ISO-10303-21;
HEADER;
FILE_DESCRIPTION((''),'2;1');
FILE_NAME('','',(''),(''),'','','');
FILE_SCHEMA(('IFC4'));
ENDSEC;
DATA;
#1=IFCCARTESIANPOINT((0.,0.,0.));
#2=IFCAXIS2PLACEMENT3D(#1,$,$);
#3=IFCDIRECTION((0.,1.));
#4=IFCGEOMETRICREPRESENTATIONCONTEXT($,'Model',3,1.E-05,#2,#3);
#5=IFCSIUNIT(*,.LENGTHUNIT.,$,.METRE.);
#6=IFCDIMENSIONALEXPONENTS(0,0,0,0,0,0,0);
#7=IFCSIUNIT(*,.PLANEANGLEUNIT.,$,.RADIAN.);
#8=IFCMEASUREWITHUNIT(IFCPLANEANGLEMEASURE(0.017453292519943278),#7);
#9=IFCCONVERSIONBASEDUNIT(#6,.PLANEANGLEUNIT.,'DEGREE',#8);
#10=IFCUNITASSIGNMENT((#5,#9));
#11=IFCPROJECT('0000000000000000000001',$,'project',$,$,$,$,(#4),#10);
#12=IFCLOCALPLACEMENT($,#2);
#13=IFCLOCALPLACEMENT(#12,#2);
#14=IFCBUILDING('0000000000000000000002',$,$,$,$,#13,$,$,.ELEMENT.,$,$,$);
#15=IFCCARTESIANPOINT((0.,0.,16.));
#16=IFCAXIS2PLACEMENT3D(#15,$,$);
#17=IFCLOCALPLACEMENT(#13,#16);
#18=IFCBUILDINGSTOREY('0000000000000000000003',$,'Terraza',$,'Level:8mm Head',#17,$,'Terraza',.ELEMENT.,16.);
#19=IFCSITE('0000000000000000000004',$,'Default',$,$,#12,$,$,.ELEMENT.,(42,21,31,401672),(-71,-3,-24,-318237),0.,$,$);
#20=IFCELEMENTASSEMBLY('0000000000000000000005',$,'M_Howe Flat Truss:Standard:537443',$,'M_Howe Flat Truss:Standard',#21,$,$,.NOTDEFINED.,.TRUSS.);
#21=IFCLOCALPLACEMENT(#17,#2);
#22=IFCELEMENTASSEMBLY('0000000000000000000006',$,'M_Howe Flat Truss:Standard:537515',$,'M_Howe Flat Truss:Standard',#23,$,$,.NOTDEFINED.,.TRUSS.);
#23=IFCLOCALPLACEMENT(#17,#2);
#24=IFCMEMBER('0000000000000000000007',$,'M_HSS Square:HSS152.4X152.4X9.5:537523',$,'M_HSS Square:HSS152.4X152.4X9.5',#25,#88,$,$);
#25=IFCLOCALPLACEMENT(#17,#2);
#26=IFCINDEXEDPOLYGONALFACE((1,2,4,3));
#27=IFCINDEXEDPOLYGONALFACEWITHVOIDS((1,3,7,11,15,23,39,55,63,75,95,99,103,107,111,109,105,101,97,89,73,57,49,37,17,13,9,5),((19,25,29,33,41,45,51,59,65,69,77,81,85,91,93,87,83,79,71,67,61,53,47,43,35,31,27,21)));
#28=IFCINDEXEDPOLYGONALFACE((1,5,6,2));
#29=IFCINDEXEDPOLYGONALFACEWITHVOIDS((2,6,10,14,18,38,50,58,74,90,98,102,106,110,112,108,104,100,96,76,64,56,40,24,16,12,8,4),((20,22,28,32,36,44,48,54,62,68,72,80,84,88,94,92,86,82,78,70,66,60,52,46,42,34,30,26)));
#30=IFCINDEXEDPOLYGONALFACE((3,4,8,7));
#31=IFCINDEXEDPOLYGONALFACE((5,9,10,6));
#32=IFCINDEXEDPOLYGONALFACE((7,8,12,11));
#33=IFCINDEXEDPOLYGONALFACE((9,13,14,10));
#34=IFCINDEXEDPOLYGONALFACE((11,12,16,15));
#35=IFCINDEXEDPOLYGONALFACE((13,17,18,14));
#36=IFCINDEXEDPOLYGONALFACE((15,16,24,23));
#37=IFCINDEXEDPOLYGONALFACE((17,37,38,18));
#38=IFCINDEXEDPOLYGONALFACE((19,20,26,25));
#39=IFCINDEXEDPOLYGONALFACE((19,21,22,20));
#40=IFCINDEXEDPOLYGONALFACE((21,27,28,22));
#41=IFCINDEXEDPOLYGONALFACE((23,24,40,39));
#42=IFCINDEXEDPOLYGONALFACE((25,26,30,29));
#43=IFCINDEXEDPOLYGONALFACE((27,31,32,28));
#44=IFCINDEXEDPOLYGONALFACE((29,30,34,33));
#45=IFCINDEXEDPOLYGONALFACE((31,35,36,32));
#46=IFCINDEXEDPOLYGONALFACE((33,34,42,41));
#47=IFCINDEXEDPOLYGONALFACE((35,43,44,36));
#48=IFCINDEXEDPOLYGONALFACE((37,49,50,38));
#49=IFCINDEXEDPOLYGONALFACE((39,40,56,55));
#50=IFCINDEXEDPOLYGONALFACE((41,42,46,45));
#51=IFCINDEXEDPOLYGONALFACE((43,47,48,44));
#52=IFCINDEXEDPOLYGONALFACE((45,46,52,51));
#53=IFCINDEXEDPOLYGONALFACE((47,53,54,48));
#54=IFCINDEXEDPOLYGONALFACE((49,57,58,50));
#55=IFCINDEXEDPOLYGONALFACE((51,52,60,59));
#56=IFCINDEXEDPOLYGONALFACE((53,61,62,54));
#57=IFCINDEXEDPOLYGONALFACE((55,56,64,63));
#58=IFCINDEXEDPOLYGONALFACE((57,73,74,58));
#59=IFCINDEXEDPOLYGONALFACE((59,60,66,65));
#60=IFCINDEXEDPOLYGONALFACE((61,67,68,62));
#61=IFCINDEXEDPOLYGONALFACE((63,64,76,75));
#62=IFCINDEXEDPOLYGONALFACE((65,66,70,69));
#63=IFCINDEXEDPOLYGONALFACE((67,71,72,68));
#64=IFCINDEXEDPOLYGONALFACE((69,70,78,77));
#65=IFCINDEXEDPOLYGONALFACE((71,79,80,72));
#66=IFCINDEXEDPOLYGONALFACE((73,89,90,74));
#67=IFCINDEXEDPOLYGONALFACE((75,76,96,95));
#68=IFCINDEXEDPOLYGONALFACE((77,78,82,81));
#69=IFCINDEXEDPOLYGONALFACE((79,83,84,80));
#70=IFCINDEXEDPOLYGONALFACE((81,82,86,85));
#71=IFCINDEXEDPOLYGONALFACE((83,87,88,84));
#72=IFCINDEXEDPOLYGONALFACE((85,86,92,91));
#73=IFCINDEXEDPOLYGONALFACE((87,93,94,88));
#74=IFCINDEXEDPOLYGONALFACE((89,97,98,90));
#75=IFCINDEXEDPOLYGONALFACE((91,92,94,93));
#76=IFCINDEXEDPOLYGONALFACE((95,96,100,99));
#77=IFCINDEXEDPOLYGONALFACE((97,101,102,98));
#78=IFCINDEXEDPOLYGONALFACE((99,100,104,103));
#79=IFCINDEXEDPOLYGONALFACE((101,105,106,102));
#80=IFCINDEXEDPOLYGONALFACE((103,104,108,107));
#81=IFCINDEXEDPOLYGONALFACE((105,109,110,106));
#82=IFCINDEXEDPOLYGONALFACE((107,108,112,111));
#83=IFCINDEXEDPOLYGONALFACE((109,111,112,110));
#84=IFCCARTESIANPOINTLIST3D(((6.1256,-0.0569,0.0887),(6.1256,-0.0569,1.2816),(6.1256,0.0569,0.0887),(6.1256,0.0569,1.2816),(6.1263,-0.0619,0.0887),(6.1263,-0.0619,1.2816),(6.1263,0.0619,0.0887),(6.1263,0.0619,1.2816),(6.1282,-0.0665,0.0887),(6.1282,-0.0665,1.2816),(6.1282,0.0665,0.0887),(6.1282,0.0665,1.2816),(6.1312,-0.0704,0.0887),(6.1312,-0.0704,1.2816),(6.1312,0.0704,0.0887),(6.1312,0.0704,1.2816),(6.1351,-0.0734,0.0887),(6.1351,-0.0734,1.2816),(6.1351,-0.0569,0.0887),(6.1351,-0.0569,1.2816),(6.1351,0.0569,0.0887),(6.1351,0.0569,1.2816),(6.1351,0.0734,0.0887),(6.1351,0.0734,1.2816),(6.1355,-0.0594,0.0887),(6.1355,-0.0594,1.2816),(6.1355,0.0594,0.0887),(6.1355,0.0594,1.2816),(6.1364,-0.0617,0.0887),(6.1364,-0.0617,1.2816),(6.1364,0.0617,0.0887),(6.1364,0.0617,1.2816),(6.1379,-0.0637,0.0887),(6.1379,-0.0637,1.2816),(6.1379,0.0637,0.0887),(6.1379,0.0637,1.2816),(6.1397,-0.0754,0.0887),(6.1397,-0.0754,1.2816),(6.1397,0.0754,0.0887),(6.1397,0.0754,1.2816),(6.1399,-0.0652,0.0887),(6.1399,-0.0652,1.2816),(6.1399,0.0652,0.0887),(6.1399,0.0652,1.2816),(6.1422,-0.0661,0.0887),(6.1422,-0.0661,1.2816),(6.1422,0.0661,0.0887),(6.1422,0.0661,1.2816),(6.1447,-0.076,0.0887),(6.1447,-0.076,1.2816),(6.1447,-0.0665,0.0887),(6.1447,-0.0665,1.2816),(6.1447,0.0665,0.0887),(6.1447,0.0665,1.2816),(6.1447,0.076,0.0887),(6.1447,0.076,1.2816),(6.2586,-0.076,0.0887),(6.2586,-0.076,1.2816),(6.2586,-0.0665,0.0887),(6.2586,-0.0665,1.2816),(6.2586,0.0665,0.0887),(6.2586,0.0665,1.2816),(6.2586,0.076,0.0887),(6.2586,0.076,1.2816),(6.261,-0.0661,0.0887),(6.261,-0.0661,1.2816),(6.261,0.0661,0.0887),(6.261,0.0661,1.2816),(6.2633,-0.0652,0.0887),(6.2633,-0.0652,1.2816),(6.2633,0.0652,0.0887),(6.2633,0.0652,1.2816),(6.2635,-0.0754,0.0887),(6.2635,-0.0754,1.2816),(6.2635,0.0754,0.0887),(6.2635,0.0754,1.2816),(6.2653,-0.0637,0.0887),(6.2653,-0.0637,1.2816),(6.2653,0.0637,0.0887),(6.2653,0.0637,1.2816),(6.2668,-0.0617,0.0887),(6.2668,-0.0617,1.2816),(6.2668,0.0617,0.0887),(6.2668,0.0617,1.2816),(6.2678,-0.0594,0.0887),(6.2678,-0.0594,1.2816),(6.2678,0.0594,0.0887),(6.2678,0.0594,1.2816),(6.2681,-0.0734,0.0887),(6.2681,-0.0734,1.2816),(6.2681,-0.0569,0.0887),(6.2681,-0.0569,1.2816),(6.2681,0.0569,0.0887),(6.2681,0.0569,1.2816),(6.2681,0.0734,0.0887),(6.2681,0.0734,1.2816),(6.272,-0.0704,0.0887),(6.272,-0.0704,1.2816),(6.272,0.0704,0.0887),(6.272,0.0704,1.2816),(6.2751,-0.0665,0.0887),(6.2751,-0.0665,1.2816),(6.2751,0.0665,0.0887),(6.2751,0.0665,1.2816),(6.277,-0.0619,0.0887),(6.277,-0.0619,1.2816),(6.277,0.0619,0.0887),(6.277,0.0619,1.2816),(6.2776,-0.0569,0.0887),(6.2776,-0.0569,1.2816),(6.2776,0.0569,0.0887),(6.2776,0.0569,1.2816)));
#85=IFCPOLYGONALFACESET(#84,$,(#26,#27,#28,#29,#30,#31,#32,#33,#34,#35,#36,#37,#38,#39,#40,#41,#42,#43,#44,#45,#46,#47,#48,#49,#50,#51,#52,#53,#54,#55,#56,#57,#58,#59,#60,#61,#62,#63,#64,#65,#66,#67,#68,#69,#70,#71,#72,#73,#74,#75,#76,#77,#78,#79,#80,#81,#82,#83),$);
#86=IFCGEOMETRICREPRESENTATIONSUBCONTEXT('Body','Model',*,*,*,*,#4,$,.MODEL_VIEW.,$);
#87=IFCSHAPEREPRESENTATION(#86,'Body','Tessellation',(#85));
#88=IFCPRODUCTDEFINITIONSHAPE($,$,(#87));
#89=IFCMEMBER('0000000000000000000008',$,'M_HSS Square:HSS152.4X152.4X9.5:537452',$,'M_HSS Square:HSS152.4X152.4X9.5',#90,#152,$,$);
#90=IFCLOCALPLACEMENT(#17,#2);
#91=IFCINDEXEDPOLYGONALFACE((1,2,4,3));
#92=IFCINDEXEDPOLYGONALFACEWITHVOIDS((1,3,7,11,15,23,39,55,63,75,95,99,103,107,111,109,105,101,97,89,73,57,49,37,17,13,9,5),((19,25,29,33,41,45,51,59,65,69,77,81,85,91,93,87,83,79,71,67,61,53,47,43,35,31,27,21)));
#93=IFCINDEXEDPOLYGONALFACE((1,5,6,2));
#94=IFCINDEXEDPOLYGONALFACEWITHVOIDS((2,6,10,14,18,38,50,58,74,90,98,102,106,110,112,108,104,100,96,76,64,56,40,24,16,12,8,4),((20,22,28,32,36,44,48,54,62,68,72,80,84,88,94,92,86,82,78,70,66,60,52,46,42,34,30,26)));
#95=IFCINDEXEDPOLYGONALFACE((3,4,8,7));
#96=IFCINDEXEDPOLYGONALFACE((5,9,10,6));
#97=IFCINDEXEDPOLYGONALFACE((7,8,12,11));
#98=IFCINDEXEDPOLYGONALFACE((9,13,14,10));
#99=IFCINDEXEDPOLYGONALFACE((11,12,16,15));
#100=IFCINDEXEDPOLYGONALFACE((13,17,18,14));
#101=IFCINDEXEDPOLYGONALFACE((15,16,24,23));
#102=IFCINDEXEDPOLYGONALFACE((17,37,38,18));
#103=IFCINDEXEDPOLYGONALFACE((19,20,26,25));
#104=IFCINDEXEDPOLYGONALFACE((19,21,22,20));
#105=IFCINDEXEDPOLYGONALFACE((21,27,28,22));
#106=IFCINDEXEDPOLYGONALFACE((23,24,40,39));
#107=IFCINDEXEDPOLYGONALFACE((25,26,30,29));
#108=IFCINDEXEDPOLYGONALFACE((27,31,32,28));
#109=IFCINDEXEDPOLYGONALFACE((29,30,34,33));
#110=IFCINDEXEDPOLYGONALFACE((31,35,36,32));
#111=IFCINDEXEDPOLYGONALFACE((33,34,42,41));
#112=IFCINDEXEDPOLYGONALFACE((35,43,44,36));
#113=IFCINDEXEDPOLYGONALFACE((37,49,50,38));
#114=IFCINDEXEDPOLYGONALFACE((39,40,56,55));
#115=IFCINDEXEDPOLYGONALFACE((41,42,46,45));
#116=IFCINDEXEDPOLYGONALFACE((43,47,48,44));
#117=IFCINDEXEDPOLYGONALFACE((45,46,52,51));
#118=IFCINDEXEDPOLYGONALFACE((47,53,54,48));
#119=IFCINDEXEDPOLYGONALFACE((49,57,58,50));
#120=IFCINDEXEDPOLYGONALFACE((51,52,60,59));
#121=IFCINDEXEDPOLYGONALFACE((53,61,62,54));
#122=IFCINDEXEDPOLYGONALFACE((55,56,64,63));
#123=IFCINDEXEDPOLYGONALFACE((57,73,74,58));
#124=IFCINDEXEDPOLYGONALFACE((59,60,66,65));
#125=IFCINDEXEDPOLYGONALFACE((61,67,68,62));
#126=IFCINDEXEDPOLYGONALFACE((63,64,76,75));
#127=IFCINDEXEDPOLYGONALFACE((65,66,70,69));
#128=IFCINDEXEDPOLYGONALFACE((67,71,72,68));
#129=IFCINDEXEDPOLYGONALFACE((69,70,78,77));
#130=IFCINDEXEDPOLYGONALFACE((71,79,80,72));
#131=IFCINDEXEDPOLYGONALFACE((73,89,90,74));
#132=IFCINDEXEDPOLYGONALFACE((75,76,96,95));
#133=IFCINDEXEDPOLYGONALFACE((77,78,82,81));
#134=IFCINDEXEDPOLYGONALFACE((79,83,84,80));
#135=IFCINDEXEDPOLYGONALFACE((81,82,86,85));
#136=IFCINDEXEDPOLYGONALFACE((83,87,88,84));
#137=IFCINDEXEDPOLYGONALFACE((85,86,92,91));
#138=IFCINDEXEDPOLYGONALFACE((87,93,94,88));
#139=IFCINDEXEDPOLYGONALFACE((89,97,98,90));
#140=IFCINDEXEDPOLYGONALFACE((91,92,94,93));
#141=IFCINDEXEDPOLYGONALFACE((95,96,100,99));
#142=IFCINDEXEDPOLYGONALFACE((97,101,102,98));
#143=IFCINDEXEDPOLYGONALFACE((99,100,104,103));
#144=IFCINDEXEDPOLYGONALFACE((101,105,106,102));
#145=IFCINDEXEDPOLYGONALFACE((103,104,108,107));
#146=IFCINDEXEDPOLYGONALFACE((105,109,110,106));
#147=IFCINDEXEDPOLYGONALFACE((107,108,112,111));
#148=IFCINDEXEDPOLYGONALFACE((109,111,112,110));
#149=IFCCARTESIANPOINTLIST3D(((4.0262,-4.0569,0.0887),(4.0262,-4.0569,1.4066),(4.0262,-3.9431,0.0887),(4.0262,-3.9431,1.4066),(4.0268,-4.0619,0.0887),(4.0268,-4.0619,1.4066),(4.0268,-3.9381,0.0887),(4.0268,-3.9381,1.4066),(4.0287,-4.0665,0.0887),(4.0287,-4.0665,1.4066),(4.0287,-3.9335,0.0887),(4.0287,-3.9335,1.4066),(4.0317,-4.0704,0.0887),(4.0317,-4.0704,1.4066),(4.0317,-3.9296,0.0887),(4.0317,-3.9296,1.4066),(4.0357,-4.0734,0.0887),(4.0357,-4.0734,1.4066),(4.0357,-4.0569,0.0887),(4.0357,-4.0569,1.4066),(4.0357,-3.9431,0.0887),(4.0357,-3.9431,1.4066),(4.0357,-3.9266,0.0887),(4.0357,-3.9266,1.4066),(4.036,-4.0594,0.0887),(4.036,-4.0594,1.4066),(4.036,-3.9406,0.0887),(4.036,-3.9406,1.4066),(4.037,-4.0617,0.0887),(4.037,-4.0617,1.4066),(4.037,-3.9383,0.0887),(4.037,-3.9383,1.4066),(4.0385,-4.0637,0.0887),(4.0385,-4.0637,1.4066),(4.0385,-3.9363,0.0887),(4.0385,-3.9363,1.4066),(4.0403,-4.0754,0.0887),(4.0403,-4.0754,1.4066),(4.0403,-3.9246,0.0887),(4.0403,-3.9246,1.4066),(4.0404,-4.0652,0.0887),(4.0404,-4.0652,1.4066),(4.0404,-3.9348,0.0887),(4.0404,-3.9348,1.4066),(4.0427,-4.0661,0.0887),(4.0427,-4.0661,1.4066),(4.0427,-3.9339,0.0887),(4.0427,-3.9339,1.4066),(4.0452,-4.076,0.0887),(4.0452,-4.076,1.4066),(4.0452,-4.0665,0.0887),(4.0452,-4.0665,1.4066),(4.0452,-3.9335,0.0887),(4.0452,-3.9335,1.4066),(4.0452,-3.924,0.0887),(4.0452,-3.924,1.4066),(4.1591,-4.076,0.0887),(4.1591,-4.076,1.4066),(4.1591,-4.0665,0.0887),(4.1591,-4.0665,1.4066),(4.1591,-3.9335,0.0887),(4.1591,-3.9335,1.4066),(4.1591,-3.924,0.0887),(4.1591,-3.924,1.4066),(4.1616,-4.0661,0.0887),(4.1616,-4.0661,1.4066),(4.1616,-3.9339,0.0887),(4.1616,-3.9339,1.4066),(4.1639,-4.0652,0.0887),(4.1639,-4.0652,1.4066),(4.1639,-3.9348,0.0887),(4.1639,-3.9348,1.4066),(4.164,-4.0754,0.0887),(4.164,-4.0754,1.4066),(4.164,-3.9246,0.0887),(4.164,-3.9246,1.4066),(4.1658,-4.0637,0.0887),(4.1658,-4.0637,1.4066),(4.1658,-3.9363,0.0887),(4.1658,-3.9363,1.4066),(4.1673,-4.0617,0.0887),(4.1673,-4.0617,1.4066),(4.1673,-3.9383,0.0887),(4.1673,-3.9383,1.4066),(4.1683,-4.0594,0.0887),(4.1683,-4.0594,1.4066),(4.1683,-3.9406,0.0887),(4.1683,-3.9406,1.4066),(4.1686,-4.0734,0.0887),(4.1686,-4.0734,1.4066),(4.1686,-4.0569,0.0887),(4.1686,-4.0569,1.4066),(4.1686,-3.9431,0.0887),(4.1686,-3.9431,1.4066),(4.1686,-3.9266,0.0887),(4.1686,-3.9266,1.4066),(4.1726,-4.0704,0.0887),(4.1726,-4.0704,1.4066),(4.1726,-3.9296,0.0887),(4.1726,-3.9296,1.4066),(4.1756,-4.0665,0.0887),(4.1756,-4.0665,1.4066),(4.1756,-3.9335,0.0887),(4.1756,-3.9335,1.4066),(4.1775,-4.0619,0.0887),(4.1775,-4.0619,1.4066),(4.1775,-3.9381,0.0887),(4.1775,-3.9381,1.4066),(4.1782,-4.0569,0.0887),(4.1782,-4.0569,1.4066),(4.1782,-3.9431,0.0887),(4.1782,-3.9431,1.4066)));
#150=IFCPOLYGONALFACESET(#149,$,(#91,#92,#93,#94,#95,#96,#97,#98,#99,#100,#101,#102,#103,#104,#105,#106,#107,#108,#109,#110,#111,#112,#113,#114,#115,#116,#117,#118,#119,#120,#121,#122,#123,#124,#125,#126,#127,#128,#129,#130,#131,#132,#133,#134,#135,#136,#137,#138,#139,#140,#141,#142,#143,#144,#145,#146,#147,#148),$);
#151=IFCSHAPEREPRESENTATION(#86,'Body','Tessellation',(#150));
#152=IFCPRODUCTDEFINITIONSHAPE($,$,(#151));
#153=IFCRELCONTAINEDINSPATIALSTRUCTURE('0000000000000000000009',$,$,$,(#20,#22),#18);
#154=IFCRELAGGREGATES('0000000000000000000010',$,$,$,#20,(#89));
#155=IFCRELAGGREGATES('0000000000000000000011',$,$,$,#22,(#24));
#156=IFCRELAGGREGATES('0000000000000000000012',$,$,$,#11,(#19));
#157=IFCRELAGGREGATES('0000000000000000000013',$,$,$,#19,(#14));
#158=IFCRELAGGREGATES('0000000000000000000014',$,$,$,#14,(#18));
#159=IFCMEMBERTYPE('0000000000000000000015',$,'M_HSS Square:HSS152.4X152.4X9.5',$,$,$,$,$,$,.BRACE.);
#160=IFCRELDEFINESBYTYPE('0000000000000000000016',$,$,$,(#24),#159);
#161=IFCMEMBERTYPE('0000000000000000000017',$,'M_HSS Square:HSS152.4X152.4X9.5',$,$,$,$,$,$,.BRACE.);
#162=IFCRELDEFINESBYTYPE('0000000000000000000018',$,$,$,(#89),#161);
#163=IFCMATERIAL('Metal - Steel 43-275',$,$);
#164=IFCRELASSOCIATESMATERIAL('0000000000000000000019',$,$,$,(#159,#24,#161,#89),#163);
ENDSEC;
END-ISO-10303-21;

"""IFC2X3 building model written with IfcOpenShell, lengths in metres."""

from ifc_helpers import new_model, entity, si_unit, converted_unit, direction, frame, frame_2d, origin, place, context, subcontext, project, spatial, polyline, circle_curve, parameter, trimmed, segment, composite_curve, outline, extrude, source, transform, mapped, material, type_object, type_shapes, element, aggregate, save


model = new_model("IFC2X3")

# Units and contexts
model_context = context("Model", 3, precision=1e-05, world=origin(), true_north=direction((0.0, 1.0)))
body_context = subcontext(model_context, "Body", "Model", "MODEL_VIEW")
ifc_project = project(units=[si_unit("LENGTHUNIT", "METRE"), converted_unit("PLANEANGLEUNIT", "DEGREE", entity("IfcPlaneAngleMeasure", 0.017453292519943278), si_unit("PLANEANGLEUNIT", "RADIAN"), dimensions=[0, 0, 0, 0, 0, 0, 0])], contexts=[model_context])

# Site, building, storey
site_placement = place(None, origin())
site = spatial("IfcSite", under=ifc_project, at=site_placement, Name="Default", CompositionType="ELEMENT", RefLatitude=(42, 21, 31, 401672), RefLongitude=(-71, -3, -24, -318237), RefElevation=0.0)
building_placement = place(site_placement, origin())
building = spatial("IfcBuilding", under=site, at=building_placement, CompositionType="ELEMENT")
storey_placement = place(building_placement, frame((0.0, 0.0, 16.0)))
storey = spatial("IfcBuildingStorey", under=building, at=storey_placement, Name="Terraza", ObjectType="Level:8mm Head", LongName="Terraza", CompositionType="ELEMENT", Elevation=16.0)

# Element assemblies
ifc_material_1 = material(Name="Metal - Steel 43-275")
assembly_1_placement = place(storey_placement, origin())
assembly_1 = element("IfcElementAssembly", 1, at=assembly_1_placement, inside=storey, Name="M_Howe Flat Truss:Standard:537443", ObjectType="M_Howe Flat Truss:Standard", AssemblyPlace="NOTDEFINED", PredefinedType="TRUSS")
assembly_2_placement = place(storey_placement, origin())
assembly_2 = element("IfcElementAssembly", 2, at=assembly_2_placement, inside=storey, Name="M_Howe Flat Truss:Standard:537515", ObjectType="M_Howe Flat Truss:Standard", AssemblyPlace="NOTDEFINED", PredefinedType="TRUSS")

# Members
member_type_1 = type_object("IfcMemberType", Name="M_HSS Square:HSS152.4X152.4X9.5", PredefinedType="BRACE", material=ifc_material_1)
shared_shape_1 = source(origin(), body_context, "Body", "SweptSolid", [
    extrude(outline(composite_curve([segment(polyline([(-0.0569, -0.076), (0.0569, -0.076)]), True, "CONTINUOUS"), segment(trimmed(circle_curve(frame_2d((0.0569, -0.0569), x_axis=(0.0, 1.0)), 0.0191), [parameter(180.0)], [parameter(270.0)], True, "PARAMETER"), True, "CONTINUOUS"), segment(polyline([(0.076, -0.0569), (0.076, 0.0569)]), True, "CONTINUOUS"), segment(trimmed(circle_curve(frame_2d((0.0569, 0.0569), x_axis=(0.0, 1.0)), 0.0191), [parameter(270.0)], [parameter(0.0)], True, "PARAMETER"), True, "CONTINUOUS"), segment(polyline([(0.0569, 0.076), (-0.0569, 0.076)]), True, "CONTINUOUS"), segment(trimmed(circle_curve(frame_2d((-0.0569, 0.0569), x_axis=(0.0, 1.0)), 0.0191), [parameter(0.0)], [parameter(90.0)], True, "PARAMETER"), True, "CONTINUOUS"), segment(polyline([(-0.076, 0.0569), (-0.076, -0.0569)]), True, "CONTINUOUS"), segment(trimmed(circle_curve(frame_2d((-0.0569, -0.0569), x_axis=(0.0, 1.0)), 0.0191), [parameter(90.0)], [parameter(180.0)], True, "PARAMETER"), True, "CONTINUOUS")], self_intersect=False), holes=[composite_curve([segment(trimmed(circle_curve(frame_2d((-0.0569, 0.0569), x_axis=(0.0, 1.0)), 0.0095), [parameter(360.0)], [parameter(90.0)], True, "PARAMETER"), False, "CONTINUOUS"), segment(polyline([(-0.0569, 0.0665), (0.0569, 0.0665)]), True, "CONTINUOUS"), segment(trimmed(circle_curve(frame_2d((0.0569, 0.0569), x_axis=(0.0, 1.0)), 0.0095), [parameter(270.0)], [parameter(360.0)], True, "PARAMETER"), False, "CONTINUOUS"), segment(polyline([(0.0665, 0.0569), (0.0665, -0.0569)]), True, "CONTINUOUS"), segment(trimmed(circle_curve(frame_2d((0.0569, -0.0569), x_axis=(0.0, 1.0)), 0.0095), [parameter(180.0)], [parameter(270.0)], True, "PARAMETER"), False, "CONTINUOUS"), segment(polyline([(0.0569, -0.0665), (-0.0569, -0.0665)]), True, "CONTINUOUS"), segment(trimmed(circle_curve(frame_2d((-0.0569, -0.0569), x_axis=(0.0, 1.0)), 0.0095), [parameter(90.0)], [parameter(180.0)], True, "PARAMETER"), False, "CONTINUOUS"), segment(polyline([(-0.0665, -0.0569), (-0.0665, 0.0569)]), True, "CONTINUOUS")], self_intersect=False)]), frame((-0.5988, 0.0, 0.0), z_axis=(1.0, 0.0, 0.0), x_axis=(0.0, 0.0, -1.0)), (0.0, 0.0, 1.0), 1.1929),
])
type_shapes(member_type_1, [shared_shape_1])
member_1_placement = place(assembly_2_placement, frame((6.2016, 0.0, 0.6875), z_axis=(1.0, 0.0, 0.0), x_axis=(0.0, 0.0, 1.0)))
member_1 = element("IfcMember", 3, at=member_1_placement, type_object=member_type_1, material=ifc_material_1, Name="M_HSS Square:HSS152.4X152.4X9.5:537523", ObjectType="M_HSS Square:HSS152.4X152.4X9.5", context=body_context, shape_type="MappedRepresentation", body=[
    mapped(shared_shape_1, transform((0.0, 0.0, 0.0), scale=1.0)),
])
member_type_2 = type_object("IfcMemberType", Name="M_HSS Square:HSS152.4X152.4X9.5", PredefinedType="BRACE", material=ifc_material_1)
shared_shape_2 = source(origin(), body_context, "Body", "SweptSolid", [
    extrude(outline(composite_curve([segment(polyline([(-0.0569, -0.076), (0.0569, -0.076)]), True, "CONTINUOUS"), segment(trimmed(circle_curve(frame_2d((0.0569, -0.0569), x_axis=(0.0, 1.0)), 0.0191), [parameter(180.0)], [parameter(270.0)], True, "PARAMETER"), True, "CONTINUOUS"), segment(polyline([(0.076, -0.0569), (0.076, 0.0569)]), True, "CONTINUOUS"), segment(trimmed(circle_curve(frame_2d((0.0569, 0.0569), x_axis=(0.0, 1.0)), 0.0191), [parameter(270.0)], [parameter(0.0)], True, "PARAMETER"), True, "CONTINUOUS"), segment(polyline([(0.0569, 0.076), (-0.0569, 0.076)]), True, "CONTINUOUS"), segment(trimmed(circle_curve(frame_2d((-0.0569, 0.0569), x_axis=(0.0, 1.0)), 0.0191), [parameter(0.0)], [parameter(90.0)], True, "PARAMETER"), True, "CONTINUOUS"), segment(polyline([(-0.076, 0.0569), (-0.076, -0.0569)]), True, "CONTINUOUS"), segment(trimmed(circle_curve(frame_2d((-0.0569, -0.0569), x_axis=(0.0, 1.0)), 0.0191), [parameter(90.0)], [parameter(180.0)], True, "PARAMETER"), True, "CONTINUOUS")], self_intersect=False), holes=[composite_curve([segment(trimmed(circle_curve(frame_2d((-0.0569, 0.0569), x_axis=(0.0, 1.0)), 0.0095), [parameter(360.0)], [parameter(90.0)], True, "PARAMETER"), False, "CONTINUOUS"), segment(polyline([(-0.0569, 0.0665), (0.0569, 0.0665)]), True, "CONTINUOUS"), segment(trimmed(circle_curve(frame_2d((0.0569, 0.0569), x_axis=(0.0, 1.0)), 0.0095), [parameter(270.0)], [parameter(360.0)], True, "PARAMETER"), False, "CONTINUOUS"), segment(polyline([(0.0665, 0.0569), (0.0665, -0.0569)]), True, "CONTINUOUS"), segment(trimmed(circle_curve(frame_2d((0.0569, -0.0569), x_axis=(0.0, 1.0)), 0.0095), [parameter(180.0)], [parameter(270.0)], True, "PARAMETER"), False, "CONTINUOUS"), segment(polyline([(0.0569, -0.0665), (-0.0569, -0.0665)]), True, "CONTINUOUS"), segment(trimmed(circle_curve(frame_2d((-0.0569, -0.0569), x_axis=(0.0, 1.0)), 0.0095), [parameter(90.0)], [parameter(180.0)], True, "PARAMETER"), False, "CONTINUOUS"), segment(polyline([(-0.0665, -0.0569), (-0.0665, 0.0569)]), True, "CONTINUOUS")], self_intersect=False)]), frame((-0.6613, 0.0, 0.0), z_axis=(1.0, 0.0, 0.0), x_axis=(0.0, 0.0, -1.0)), (0.0, 0.0, 1.0), 1.3179),
])
type_shapes(member_type_2, [shared_shape_2])
member_2_placement = place(assembly_1_placement, frame((4.1022, -4.0, 0.75), z_axis=(1.0, 0.0, 0.0), x_axis=(0.0, 0.0, 1.0)))
member_2 = element("IfcMember", 4, at=member_2_placement, type_object=member_type_2, material=ifc_material_1, Name="M_HSS Square:HSS152.4X152.4X9.5:537452", ObjectType="M_HSS Square:HSS152.4X152.4X9.5", context=body_context, shape_type="MappedRepresentation", body=[
    mapped(shared_shape_2, transform((0.0, 0.0, 0.0), scale=1.0)),
])
aggregate(assembly_1, [member_2])
aggregate(assembly_2, [member_1])

save(model, "model.ifc")
